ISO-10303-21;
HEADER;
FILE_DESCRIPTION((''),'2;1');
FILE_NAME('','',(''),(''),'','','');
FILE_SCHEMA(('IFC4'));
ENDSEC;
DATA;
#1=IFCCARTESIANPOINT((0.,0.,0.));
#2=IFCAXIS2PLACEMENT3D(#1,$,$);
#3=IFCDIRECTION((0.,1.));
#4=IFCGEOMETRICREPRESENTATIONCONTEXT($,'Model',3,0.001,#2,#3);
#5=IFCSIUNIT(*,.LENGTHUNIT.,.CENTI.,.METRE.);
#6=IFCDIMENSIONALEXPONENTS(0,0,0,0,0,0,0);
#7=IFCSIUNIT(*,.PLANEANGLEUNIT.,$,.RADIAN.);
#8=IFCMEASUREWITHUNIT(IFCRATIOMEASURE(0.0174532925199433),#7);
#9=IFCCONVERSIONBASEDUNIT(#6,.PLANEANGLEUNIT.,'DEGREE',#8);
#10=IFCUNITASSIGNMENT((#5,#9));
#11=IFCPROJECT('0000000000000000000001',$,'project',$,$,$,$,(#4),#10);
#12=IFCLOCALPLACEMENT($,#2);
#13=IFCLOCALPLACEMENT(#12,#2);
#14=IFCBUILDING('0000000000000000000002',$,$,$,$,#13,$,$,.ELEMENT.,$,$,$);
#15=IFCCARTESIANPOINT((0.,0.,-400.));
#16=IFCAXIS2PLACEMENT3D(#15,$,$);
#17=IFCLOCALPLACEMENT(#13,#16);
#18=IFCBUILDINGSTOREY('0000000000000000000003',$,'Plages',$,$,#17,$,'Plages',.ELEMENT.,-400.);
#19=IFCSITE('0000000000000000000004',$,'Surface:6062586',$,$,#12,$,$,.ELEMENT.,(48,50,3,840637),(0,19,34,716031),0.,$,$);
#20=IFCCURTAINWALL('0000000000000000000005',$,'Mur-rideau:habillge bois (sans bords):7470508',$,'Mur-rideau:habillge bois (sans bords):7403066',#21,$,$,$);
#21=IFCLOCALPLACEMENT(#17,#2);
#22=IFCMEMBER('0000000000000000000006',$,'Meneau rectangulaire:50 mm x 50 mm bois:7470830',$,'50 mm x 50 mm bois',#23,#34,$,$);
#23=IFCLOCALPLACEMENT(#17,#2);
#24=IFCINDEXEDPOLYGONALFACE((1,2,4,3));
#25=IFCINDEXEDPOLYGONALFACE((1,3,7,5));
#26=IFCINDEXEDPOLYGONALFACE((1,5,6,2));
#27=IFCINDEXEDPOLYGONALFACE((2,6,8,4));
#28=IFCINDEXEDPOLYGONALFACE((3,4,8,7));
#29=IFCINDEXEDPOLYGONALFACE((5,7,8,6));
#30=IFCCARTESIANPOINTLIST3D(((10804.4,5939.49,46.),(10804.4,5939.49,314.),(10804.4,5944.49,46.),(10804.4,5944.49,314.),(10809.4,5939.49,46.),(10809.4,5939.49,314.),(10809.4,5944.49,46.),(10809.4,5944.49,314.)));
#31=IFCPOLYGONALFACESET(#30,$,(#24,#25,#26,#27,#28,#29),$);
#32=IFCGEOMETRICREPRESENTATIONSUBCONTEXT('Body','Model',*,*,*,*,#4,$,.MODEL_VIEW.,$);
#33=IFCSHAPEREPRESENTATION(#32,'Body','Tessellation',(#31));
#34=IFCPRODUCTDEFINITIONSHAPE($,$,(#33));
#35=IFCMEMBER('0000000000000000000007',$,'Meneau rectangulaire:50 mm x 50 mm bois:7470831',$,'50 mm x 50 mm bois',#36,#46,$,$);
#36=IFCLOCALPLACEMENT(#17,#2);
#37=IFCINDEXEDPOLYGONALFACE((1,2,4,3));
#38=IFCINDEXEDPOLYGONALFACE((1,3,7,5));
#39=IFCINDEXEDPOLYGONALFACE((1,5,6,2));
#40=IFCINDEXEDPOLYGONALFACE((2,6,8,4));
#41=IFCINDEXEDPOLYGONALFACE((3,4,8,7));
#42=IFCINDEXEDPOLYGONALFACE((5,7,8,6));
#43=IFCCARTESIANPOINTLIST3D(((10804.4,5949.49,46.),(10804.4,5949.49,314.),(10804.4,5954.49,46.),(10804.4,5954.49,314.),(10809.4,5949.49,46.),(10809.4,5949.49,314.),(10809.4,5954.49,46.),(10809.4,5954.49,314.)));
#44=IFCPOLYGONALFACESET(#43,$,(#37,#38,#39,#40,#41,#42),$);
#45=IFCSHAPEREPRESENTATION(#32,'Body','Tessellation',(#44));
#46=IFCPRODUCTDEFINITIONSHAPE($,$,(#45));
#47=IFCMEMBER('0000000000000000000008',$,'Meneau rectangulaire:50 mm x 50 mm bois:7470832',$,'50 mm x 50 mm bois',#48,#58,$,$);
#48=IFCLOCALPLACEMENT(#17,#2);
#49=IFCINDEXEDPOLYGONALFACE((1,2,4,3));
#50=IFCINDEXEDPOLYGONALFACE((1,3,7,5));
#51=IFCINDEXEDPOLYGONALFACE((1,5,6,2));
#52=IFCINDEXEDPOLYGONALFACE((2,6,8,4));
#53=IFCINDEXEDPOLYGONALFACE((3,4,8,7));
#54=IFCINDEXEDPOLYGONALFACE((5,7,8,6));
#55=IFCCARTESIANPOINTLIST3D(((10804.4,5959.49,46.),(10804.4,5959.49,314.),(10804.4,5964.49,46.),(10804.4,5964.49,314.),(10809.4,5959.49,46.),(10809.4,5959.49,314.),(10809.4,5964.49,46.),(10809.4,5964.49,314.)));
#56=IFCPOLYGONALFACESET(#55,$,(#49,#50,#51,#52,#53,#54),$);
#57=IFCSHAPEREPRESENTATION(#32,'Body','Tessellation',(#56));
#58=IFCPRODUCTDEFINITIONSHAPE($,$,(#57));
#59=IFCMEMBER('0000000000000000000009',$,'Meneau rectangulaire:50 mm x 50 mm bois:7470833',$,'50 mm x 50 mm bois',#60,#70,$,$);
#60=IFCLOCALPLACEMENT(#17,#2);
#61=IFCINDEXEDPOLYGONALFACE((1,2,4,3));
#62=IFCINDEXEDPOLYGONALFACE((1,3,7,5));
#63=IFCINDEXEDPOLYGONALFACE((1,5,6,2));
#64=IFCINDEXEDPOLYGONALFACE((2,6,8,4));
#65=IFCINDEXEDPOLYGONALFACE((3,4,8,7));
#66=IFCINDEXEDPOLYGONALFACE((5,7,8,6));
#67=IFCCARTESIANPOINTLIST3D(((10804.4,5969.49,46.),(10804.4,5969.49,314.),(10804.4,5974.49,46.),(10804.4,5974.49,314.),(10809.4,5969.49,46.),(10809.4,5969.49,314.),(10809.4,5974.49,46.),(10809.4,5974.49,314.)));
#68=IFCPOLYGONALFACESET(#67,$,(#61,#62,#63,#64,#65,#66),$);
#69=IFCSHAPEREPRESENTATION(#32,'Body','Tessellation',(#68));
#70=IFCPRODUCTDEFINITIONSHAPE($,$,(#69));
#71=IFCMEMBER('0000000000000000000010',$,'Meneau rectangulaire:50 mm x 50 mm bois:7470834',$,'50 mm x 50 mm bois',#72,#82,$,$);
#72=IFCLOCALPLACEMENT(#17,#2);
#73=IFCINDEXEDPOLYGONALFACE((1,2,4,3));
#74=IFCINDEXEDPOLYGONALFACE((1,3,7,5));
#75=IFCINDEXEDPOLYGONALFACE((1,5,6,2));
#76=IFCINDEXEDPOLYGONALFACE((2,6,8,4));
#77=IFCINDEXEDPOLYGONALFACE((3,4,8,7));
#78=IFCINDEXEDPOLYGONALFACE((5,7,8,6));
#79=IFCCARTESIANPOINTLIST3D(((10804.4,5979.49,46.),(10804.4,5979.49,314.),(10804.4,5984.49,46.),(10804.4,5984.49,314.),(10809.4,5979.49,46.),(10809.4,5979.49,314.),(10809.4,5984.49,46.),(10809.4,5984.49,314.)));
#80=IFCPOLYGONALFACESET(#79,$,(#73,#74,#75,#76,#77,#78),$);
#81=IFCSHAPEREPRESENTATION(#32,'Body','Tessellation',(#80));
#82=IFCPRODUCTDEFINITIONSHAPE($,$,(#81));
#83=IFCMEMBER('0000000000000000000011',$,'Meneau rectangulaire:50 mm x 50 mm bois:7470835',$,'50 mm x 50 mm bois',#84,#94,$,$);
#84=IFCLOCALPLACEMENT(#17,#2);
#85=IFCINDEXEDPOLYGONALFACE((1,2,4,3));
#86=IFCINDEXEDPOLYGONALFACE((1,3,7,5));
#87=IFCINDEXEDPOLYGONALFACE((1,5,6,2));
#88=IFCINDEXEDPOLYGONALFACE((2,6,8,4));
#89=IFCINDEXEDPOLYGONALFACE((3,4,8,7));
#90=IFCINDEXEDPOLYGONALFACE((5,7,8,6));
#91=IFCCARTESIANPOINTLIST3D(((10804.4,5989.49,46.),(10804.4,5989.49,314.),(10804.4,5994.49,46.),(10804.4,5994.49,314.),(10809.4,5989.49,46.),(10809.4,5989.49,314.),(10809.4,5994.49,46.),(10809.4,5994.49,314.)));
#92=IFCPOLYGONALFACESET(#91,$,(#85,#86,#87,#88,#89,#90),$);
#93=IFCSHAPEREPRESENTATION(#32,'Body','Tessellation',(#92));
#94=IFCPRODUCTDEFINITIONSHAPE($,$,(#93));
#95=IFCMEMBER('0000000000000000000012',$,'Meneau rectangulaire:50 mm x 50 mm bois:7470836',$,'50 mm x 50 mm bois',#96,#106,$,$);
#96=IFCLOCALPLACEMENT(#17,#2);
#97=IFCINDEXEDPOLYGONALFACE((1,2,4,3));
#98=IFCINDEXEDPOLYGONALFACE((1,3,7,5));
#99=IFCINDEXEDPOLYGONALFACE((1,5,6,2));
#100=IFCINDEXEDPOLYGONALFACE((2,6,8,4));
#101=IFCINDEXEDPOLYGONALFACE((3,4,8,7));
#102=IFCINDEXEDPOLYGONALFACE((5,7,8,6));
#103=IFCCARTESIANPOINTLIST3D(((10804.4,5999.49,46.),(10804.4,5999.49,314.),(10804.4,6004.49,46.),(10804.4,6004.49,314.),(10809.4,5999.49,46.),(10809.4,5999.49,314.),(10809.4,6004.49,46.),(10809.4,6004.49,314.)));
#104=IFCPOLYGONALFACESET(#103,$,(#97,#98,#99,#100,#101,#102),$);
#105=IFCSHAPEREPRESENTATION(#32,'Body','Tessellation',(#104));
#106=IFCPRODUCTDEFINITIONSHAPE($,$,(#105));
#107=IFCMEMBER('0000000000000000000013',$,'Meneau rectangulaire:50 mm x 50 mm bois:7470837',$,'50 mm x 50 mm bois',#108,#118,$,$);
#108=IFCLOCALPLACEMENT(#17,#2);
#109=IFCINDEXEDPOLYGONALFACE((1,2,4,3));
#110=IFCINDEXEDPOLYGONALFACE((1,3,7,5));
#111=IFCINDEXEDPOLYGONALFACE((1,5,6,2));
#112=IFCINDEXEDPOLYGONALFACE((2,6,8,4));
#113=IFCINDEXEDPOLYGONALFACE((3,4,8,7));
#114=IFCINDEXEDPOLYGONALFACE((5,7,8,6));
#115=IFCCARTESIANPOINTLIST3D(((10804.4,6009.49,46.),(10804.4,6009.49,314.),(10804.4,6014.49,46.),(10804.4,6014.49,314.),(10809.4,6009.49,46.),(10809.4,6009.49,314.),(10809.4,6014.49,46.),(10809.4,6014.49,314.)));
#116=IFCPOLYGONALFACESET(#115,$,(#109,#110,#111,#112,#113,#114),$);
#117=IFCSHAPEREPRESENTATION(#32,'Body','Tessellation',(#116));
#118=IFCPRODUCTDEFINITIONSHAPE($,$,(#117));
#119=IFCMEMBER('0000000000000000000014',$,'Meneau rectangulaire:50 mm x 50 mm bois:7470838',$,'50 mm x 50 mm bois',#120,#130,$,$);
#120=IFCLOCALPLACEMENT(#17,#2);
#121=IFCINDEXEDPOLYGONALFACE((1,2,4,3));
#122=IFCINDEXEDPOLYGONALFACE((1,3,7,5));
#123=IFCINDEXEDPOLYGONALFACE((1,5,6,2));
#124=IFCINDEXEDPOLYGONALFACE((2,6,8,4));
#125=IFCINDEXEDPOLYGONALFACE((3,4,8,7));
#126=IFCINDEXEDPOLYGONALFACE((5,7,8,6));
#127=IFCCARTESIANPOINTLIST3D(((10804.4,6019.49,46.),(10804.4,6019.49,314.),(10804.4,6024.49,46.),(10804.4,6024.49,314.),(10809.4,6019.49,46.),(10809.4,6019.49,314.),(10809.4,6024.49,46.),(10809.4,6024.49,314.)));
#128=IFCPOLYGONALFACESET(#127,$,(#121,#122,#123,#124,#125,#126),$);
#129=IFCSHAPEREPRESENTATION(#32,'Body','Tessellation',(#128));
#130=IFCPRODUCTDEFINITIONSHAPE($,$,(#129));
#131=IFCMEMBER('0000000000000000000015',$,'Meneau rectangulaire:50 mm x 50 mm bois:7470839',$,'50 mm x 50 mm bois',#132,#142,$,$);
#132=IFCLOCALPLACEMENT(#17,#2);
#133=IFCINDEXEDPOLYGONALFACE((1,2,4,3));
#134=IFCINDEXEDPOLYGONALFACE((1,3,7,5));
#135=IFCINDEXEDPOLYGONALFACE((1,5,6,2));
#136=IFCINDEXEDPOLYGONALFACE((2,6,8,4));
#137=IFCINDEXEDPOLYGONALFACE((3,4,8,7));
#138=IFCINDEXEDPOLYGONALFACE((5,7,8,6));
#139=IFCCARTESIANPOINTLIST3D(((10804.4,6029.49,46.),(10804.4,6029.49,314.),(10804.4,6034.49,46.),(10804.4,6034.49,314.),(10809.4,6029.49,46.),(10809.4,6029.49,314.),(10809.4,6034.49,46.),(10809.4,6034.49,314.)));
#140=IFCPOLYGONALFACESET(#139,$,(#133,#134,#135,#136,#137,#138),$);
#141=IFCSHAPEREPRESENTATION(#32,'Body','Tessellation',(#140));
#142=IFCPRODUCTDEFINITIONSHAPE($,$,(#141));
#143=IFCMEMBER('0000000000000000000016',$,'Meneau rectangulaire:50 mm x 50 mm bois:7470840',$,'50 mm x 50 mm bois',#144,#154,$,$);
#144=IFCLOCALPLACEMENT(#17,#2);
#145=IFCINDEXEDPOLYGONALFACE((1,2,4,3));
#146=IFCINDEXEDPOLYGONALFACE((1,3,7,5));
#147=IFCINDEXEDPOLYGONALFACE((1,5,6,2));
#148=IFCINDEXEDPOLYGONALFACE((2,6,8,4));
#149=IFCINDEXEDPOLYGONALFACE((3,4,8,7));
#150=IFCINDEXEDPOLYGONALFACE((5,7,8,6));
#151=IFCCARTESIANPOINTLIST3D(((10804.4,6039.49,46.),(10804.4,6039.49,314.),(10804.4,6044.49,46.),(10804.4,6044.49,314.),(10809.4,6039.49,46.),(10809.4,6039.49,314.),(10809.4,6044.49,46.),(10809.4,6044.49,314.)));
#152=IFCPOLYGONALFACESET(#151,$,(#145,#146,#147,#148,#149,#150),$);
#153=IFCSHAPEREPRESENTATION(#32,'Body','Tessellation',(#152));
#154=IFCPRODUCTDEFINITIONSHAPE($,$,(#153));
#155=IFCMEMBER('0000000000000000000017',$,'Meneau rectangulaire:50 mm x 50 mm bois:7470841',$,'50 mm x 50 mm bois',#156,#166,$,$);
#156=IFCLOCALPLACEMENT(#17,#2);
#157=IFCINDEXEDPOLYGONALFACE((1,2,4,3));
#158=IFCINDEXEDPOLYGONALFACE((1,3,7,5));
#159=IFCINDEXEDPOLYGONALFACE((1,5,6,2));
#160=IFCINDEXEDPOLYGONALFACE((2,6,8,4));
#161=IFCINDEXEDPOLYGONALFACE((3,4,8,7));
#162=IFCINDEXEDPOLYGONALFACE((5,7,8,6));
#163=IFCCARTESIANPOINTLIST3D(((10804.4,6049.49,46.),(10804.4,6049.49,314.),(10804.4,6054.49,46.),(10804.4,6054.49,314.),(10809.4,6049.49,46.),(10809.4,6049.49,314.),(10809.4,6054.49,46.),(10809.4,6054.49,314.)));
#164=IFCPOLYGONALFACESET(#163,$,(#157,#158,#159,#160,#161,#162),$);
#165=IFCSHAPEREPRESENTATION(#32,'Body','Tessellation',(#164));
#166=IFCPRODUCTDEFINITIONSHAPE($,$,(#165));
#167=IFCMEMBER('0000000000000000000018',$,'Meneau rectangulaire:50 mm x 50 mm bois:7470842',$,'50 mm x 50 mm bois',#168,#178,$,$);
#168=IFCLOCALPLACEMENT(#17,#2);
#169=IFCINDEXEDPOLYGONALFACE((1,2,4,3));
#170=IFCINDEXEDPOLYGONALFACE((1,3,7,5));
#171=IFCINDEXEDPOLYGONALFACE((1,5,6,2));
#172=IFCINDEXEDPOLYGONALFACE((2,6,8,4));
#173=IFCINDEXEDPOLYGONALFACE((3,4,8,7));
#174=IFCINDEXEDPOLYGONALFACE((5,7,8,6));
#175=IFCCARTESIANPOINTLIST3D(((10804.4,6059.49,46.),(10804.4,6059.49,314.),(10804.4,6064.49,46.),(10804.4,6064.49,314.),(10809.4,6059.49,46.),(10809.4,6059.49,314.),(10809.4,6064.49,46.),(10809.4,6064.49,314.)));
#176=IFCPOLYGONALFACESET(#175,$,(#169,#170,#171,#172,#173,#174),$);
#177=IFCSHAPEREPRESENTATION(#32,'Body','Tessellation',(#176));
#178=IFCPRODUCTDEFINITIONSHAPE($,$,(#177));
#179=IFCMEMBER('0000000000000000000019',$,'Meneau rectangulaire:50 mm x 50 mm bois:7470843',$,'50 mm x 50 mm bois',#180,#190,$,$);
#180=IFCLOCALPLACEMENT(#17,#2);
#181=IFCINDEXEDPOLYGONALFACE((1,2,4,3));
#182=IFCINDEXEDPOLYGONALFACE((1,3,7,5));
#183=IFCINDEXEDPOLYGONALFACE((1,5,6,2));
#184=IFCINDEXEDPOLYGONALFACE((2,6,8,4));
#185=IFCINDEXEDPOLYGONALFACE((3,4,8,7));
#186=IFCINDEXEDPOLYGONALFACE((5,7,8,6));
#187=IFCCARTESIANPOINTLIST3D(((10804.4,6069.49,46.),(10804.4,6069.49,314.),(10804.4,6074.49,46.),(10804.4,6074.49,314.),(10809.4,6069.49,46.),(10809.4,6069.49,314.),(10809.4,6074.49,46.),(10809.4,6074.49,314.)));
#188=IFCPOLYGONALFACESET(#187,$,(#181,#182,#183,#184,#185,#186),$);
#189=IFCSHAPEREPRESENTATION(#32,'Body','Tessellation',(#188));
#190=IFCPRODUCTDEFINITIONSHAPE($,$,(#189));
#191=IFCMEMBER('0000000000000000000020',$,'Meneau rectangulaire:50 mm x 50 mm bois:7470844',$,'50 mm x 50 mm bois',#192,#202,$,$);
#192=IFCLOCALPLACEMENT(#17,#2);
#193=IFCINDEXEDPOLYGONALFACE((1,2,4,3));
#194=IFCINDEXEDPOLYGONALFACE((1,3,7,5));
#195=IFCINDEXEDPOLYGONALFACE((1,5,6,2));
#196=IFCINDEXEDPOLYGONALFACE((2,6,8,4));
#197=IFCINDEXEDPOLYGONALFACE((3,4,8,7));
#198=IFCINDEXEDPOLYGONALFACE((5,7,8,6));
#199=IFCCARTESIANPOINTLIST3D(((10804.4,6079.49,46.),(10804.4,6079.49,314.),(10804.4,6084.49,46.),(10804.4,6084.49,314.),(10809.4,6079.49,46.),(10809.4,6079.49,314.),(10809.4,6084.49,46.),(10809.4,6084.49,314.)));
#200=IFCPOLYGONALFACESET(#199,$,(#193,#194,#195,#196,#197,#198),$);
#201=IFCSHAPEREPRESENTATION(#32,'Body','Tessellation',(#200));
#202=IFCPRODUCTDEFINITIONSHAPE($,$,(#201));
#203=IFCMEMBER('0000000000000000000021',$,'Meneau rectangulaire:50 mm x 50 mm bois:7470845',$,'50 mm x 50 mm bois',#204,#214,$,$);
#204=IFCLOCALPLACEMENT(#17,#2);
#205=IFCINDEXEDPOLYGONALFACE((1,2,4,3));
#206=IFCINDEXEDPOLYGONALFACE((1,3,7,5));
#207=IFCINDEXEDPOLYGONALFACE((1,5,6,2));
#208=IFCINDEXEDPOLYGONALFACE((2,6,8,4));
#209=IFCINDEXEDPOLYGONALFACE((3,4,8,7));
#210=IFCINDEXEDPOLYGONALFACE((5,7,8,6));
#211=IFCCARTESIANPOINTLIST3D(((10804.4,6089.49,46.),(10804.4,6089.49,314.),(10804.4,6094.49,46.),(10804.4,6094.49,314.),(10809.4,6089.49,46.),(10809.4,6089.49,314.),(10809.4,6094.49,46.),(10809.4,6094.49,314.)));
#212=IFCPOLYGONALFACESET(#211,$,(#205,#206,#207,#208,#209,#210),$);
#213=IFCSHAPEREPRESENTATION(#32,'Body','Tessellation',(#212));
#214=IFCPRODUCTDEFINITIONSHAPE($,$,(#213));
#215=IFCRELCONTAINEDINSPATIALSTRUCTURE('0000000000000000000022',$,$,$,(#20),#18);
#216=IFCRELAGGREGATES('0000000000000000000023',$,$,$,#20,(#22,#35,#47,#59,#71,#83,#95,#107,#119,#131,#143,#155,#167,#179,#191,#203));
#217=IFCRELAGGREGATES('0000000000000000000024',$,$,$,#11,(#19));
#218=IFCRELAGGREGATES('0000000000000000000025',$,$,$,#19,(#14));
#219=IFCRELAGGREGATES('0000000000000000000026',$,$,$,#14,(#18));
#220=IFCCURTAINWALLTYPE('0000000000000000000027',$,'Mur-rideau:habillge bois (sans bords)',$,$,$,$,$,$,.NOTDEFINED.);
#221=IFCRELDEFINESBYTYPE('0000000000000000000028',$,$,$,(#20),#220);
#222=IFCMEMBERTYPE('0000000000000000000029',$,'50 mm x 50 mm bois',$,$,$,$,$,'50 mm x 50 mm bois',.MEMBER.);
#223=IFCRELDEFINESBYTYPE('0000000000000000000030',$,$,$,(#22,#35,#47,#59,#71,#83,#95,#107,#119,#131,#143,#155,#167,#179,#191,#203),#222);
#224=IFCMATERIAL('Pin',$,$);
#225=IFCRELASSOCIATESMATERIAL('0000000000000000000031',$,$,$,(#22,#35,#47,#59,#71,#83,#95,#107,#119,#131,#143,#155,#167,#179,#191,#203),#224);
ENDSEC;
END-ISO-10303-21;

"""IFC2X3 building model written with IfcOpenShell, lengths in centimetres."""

from ifc_helpers import new_model, entity, si_unit, converted_unit, direction, frame, origin, origin_2d_with_axis, place, context, subcontext, project, spatial, rectangle, extrude, source, transform, mapped, material, type_object, type_shapes, element, aggregate, save


model = new_model("IFC2X3")

# Units and contexts
model_context = context("Model", 3, precision=0.001, world=origin(), true_north=direction((0.0, 1.0)))
body_context = subcontext(model_context, "Body", "Model", "MODEL_VIEW")
ifc_project = project(units=[si_unit("LENGTHUNIT", "METRE", prefix="CENTI"), converted_unit("PLANEANGLEUNIT", "DEGREE", entity("IfcRatioMeasure", 0.0174532925199433), si_unit("PLANEANGLEUNIT", "RADIAN"), dimensions=[0, 0, 0, 0, 0, 0, 0])], contexts=[model_context])

# Site, building, storey
site_placement = place(None, origin())
site = spatial("IfcSite", under=ifc_project, at=site_placement, Name="Surface:6062586", CompositionType="ELEMENT", RefLatitude=(48, 50, 3, 840637), RefLongitude=(0, 19, 34, 716031), RefElevation=0.0)
building_placement = place(site_placement, origin())
building = spatial("IfcBuilding", under=site, at=building_placement, CompositionType="ELEMENT")
storey_placement = place(building_placement, frame((0.0, 0.0, -400.0)))
storey = spatial("IfcBuildingStorey", under=building, at=storey_placement, Name="Plages", LongName="Plages", CompositionType="ELEMENT", Elevation=-400.0)

# Curtain wall, members
curtain_wall_type = type_object("IfcCurtainWallType", Name="Mur-rideau:habillge bois (sans bords)", PredefinedType="NOTDEFINED")
curtain_wall_placement = place(storey_placement, frame((0.0, 0.0, 400.0)))
curtain_wall = element("IfcCurtainWall", 1, at=curtain_wall_placement, inside=storey, type_object=curtain_wall_type, Name="Mur-rideau:habillge bois (sans bords):7470508", ObjectType="Mur-rideau:habillge bois (sans bords):7403066")
ifc_material = material(Name="Pin")
member_type = type_object("IfcMemberType", Name="50 mm x 50 mm bois", ElementType="50 mm x 50 mm bois", PredefinedType="MEMBER")
shared_shape = source(origin(), body_context, "Body", "SweptSolid", [
    extrude(rectangle(XDim=5.0, YDim=5.0, at=origin_2d_with_axis()), frame((0.0, 0.0, -268.0), z_axis=(0.0, 0.0, 1.0), x_axis=(0.0, -1.0, 0.0)), (0.0, 0.0, 1.0), 268.0),
])
type_shapes(member_type, [shared_shape])
member_1_placement = place(storey_placement, frame((10806.9, 5941.99, 46.0), z_axis=(0.0, 0.0, -1.0), x_axis=(0.0, 1.0, 0.0)))
member_1 = element("IfcMember", 2, at=member_1_placement, type_object=member_type, material=ifc_material, Name="Meneau rectangulaire:50 mm x 50 mm bois:7470830", ObjectType="50 mm x 50 mm bois", context=body_context, shape_type="MappedRepresentation", body=[
    mapped(shared_shape, transform((0.0, 0.0, 0.0), scale=1.0)),
])
member_2_placement = place(storey_placement, frame((10806.9, 5951.99, 46.0), z_axis=(0.0, 0.0, -1.0), x_axis=(0.0, 1.0, 0.0)))
member_2 = element("IfcMember", 3, at=member_2_placement, type_object=member_type, material=ifc_material, Name="Meneau rectangulaire:50 mm x 50 mm bois:7470831", ObjectType="50 mm x 50 mm bois", context=body_context, shape_type="MappedRepresentation", body=[
    mapped(shared_shape, transform((0.0, 0.0, 0.0), scale=1.0)),
])
member_3_placement = place(storey_placement, frame((10806.9, 5961.99, 46.0), z_axis=(0.0, 0.0, -1.0), x_axis=(0.0, 1.0, 0.0)))
member_3 = element("IfcMember", 4, at=member_3_placement, type_object=member_type, material=ifc_material, Name="Meneau rectangulaire:50 mm x 50 mm bois:7470832", ObjectType="50 mm x 50 mm bois", context=body_context, shape_type="MappedRepresentation", body=[
    mapped(shared_shape, transform((0.0, 0.0, 0.0), scale=1.0)),
])
member_4_placement = place(storey_placement, frame((10806.9, 5971.99, 46.0), z_axis=(0.0, 0.0, -1.0), x_axis=(0.0, 1.0, 0.0)))
member_4 = element("IfcMember", 5, at=member_4_placement, type_object=member_type, material=ifc_material, Name="Meneau rectangulaire:50 mm x 50 mm bois:7470833", ObjectType="50 mm x 50 mm bois", context=body_context, shape_type="MappedRepresentation", body=[
    mapped(shared_shape, transform((0.0, 0.0, 0.0), scale=1.0)),
])
member_5_placement = place(storey_placement, frame((10806.9, 5981.99, 46.0), z_axis=(0.0, 0.0, -1.0), x_axis=(0.0, 1.0, 0.0)))
member_5 = element("IfcMember", 6, at=member_5_placement, type_object=member_type, material=ifc_material, Name="Meneau rectangulaire:50 mm x 50 mm bois:7470834", ObjectType="50 mm x 50 mm bois", context=body_context, shape_type="MappedRepresentation", body=[
    mapped(shared_shape, transform((0.0, 0.0, 0.0), scale=1.0)),
])
member_6_placement = place(storey_placement, frame((10806.9, 5991.99, 46.0), z_axis=(0.0, 0.0, -1.0), x_axis=(0.0, 1.0, 0.0)))
member_6 = element("IfcMember", 7, at=member_6_placement, type_object=member_type, material=ifc_material, Name="Meneau rectangulaire:50 mm x 50 mm bois:7470835", ObjectType="50 mm x 50 mm bois", context=body_context, shape_type="MappedRepresentation", body=[
    mapped(shared_shape, transform((0.0, 0.0, 0.0), scale=1.0)),
])
member_7_placement = place(storey_placement, frame((10806.9, 6001.99, 46.0), z_axis=(0.0, 0.0, -1.0), x_axis=(0.0, 1.0, 0.0)))
member_7 = element("IfcMember", 8, at=member_7_placement, type_object=member_type, material=ifc_material, Name="Meneau rectangulaire:50 mm x 50 mm bois:7470836", ObjectType="50 mm x 50 mm bois", context=body_context, shape_type="MappedRepresentation", body=[
    mapped(shared_shape, transform((0.0, 0.0, 0.0), scale=1.0)),
])
member_8_placement = place(storey_placement, frame((10806.9, 6011.99, 46.0), z_axis=(0.0, 0.0, -1.0), x_axis=(0.0, 1.0, 0.0)))
member_8 = element("IfcMember", 9, at=member_8_placement, type_object=member_type, material=ifc_material, Name="Meneau rectangulaire:50 mm x 50 mm bois:7470837", ObjectType="50 mm x 50 mm bois", context=body_context, shape_type="MappedRepresentation", body=[
    mapped(shared_shape, transform((0.0, 0.0, 0.0), scale=1.0)),
])
member_9_placement = place(storey_placement, frame((10806.9, 6021.99, 46.0), z_axis=(0.0, 0.0, -1.0), x_axis=(0.0, 1.0, 0.0)))
member_9 = element("IfcMember", 10, at=member_9_placement, type_object=member_type, material=ifc_material, Name="Meneau rectangulaire:50 mm x 50 mm bois:7470838", ObjectType="50 mm x 50 mm bois", context=body_context, shape_type="MappedRepresentation", body=[
    mapped(shared_shape, transform((0.0, 0.0, 0.0), scale=1.0)),
])
member_10_placement = place(storey_placement, frame((10806.9, 6031.99, 46.0), z_axis=(0.0, 0.0, -1.0), x_axis=(0.0, 1.0, 0.0)))
member_10 = element("IfcMember", 11, at=member_10_placement, type_object=member_type, material=ifc_material, Name="Meneau rectangulaire:50 mm x 50 mm bois:7470839", ObjectType="50 mm x 50 mm bois", context=body_context, shape_type="MappedRepresentation", body=[
    mapped(shared_shape, transform((0.0, 0.0, 0.0), scale=1.0)),
])
member_11_placement = place(storey_placement, frame((10806.9, 6041.99, 46.0), z_axis=(0.0, 0.0, -1.0), x_axis=(0.0, 1.0, 0.0)))
member_11 = element("IfcMember", 12, at=member_11_placement, type_object=member_type, material=ifc_material, Name="Meneau rectangulaire:50 mm x 50 mm bois:7470840", ObjectType="50 mm x 50 mm bois", context=body_context, shape_type="MappedRepresentation", body=[
    mapped(shared_shape, transform((0.0, 0.0, 0.0), scale=1.0)),
])
member_12_placement = place(storey_placement, frame((10806.9, 6051.99, 46.0), z_axis=(0.0, 0.0, -1.0), x_axis=(0.0, 1.0, 0.0)))
member_12 = element("IfcMember", 13, at=member_12_placement, type_object=member_type, material=ifc_material, Name="Meneau rectangulaire:50 mm x 50 mm bois:7470841", ObjectType="50 mm x 50 mm bois", context=body_context, shape_type="MappedRepresentation", body=[
    mapped(shared_shape, transform((0.0, 0.0, 0.0), scale=1.0)),
])
member_13_placement = place(storey_placement, frame((10806.9, 6061.99, 46.0), z_axis=(0.0, 0.0, -1.0), x_axis=(0.0, 1.0, 0.0)))
member_13 = element("IfcMember", 14, at=member_13_placement, type_object=member_type, material=ifc_material, Name="Meneau rectangulaire:50 mm x 50 mm bois:7470842", ObjectType="50 mm x 50 mm bois", context=body_context, shape_type="MappedRepresentation", body=[
    mapped(shared_shape, transform((0.0, 0.0, 0.0), scale=1.0)),
])
member_14_placement = place(storey_placement, frame((10806.9, 6071.99, 46.0), z_axis=(0.0, 0.0, -1.0), x_axis=(0.0, 1.0, 0.0)))
member_14 = element("IfcMember", 15, at=member_14_placement, type_object=member_type, material=ifc_material, Name="Meneau rectangulaire:50 mm x 50 mm bois:7470843", ObjectType="50 mm x 50 mm bois", context=body_context, shape_type="MappedRepresentation", body=[
    mapped(shared_shape, transform((0.0, 0.0, 0.0), scale=1.0)),
])
member_15_placement = place(storey_placement, frame((10806.9, 6081.99, 46.0), z_axis=(0.0, 0.0, -1.0), x_axis=(0.0, 1.0, 0.0)))
member_15 = element("IfcMember", 16, at=member_15_placement, type_object=member_type, material=ifc_material, Name="Meneau rectangulaire:50 mm x 50 mm bois:7470844", ObjectType="50 mm x 50 mm bois", context=body_context, shape_type="MappedRepresentation", body=[
    mapped(shared_shape, transform((0.0, 0.0, 0.0), scale=1.0)),
])
member_16_placement = place(storey_placement, frame((10806.9, 6091.99, 46.0), z_axis=(0.0, 0.0, -1.0), x_axis=(0.0, 1.0, 0.0)))
member_16 = element("IfcMember", 17, at=member_16_placement, type_object=member_type, material=ifc_material, Name="Meneau rectangulaire:50 mm x 50 mm bois:7470845", ObjectType="50 mm x 50 mm bois", context=body_context, shape_type="MappedRepresentation", body=[
    mapped(shared_shape, transform((0.0, 0.0, 0.0), scale=1.0)),
])
aggregate(curtain_wall, [member_1, member_2, member_3, member_4, member_5, member_6, member_7, member_8, member_9, member_10, member_11, member_12, member_13, member_14, member_15, member_16])

save(model, "model.ifc")
